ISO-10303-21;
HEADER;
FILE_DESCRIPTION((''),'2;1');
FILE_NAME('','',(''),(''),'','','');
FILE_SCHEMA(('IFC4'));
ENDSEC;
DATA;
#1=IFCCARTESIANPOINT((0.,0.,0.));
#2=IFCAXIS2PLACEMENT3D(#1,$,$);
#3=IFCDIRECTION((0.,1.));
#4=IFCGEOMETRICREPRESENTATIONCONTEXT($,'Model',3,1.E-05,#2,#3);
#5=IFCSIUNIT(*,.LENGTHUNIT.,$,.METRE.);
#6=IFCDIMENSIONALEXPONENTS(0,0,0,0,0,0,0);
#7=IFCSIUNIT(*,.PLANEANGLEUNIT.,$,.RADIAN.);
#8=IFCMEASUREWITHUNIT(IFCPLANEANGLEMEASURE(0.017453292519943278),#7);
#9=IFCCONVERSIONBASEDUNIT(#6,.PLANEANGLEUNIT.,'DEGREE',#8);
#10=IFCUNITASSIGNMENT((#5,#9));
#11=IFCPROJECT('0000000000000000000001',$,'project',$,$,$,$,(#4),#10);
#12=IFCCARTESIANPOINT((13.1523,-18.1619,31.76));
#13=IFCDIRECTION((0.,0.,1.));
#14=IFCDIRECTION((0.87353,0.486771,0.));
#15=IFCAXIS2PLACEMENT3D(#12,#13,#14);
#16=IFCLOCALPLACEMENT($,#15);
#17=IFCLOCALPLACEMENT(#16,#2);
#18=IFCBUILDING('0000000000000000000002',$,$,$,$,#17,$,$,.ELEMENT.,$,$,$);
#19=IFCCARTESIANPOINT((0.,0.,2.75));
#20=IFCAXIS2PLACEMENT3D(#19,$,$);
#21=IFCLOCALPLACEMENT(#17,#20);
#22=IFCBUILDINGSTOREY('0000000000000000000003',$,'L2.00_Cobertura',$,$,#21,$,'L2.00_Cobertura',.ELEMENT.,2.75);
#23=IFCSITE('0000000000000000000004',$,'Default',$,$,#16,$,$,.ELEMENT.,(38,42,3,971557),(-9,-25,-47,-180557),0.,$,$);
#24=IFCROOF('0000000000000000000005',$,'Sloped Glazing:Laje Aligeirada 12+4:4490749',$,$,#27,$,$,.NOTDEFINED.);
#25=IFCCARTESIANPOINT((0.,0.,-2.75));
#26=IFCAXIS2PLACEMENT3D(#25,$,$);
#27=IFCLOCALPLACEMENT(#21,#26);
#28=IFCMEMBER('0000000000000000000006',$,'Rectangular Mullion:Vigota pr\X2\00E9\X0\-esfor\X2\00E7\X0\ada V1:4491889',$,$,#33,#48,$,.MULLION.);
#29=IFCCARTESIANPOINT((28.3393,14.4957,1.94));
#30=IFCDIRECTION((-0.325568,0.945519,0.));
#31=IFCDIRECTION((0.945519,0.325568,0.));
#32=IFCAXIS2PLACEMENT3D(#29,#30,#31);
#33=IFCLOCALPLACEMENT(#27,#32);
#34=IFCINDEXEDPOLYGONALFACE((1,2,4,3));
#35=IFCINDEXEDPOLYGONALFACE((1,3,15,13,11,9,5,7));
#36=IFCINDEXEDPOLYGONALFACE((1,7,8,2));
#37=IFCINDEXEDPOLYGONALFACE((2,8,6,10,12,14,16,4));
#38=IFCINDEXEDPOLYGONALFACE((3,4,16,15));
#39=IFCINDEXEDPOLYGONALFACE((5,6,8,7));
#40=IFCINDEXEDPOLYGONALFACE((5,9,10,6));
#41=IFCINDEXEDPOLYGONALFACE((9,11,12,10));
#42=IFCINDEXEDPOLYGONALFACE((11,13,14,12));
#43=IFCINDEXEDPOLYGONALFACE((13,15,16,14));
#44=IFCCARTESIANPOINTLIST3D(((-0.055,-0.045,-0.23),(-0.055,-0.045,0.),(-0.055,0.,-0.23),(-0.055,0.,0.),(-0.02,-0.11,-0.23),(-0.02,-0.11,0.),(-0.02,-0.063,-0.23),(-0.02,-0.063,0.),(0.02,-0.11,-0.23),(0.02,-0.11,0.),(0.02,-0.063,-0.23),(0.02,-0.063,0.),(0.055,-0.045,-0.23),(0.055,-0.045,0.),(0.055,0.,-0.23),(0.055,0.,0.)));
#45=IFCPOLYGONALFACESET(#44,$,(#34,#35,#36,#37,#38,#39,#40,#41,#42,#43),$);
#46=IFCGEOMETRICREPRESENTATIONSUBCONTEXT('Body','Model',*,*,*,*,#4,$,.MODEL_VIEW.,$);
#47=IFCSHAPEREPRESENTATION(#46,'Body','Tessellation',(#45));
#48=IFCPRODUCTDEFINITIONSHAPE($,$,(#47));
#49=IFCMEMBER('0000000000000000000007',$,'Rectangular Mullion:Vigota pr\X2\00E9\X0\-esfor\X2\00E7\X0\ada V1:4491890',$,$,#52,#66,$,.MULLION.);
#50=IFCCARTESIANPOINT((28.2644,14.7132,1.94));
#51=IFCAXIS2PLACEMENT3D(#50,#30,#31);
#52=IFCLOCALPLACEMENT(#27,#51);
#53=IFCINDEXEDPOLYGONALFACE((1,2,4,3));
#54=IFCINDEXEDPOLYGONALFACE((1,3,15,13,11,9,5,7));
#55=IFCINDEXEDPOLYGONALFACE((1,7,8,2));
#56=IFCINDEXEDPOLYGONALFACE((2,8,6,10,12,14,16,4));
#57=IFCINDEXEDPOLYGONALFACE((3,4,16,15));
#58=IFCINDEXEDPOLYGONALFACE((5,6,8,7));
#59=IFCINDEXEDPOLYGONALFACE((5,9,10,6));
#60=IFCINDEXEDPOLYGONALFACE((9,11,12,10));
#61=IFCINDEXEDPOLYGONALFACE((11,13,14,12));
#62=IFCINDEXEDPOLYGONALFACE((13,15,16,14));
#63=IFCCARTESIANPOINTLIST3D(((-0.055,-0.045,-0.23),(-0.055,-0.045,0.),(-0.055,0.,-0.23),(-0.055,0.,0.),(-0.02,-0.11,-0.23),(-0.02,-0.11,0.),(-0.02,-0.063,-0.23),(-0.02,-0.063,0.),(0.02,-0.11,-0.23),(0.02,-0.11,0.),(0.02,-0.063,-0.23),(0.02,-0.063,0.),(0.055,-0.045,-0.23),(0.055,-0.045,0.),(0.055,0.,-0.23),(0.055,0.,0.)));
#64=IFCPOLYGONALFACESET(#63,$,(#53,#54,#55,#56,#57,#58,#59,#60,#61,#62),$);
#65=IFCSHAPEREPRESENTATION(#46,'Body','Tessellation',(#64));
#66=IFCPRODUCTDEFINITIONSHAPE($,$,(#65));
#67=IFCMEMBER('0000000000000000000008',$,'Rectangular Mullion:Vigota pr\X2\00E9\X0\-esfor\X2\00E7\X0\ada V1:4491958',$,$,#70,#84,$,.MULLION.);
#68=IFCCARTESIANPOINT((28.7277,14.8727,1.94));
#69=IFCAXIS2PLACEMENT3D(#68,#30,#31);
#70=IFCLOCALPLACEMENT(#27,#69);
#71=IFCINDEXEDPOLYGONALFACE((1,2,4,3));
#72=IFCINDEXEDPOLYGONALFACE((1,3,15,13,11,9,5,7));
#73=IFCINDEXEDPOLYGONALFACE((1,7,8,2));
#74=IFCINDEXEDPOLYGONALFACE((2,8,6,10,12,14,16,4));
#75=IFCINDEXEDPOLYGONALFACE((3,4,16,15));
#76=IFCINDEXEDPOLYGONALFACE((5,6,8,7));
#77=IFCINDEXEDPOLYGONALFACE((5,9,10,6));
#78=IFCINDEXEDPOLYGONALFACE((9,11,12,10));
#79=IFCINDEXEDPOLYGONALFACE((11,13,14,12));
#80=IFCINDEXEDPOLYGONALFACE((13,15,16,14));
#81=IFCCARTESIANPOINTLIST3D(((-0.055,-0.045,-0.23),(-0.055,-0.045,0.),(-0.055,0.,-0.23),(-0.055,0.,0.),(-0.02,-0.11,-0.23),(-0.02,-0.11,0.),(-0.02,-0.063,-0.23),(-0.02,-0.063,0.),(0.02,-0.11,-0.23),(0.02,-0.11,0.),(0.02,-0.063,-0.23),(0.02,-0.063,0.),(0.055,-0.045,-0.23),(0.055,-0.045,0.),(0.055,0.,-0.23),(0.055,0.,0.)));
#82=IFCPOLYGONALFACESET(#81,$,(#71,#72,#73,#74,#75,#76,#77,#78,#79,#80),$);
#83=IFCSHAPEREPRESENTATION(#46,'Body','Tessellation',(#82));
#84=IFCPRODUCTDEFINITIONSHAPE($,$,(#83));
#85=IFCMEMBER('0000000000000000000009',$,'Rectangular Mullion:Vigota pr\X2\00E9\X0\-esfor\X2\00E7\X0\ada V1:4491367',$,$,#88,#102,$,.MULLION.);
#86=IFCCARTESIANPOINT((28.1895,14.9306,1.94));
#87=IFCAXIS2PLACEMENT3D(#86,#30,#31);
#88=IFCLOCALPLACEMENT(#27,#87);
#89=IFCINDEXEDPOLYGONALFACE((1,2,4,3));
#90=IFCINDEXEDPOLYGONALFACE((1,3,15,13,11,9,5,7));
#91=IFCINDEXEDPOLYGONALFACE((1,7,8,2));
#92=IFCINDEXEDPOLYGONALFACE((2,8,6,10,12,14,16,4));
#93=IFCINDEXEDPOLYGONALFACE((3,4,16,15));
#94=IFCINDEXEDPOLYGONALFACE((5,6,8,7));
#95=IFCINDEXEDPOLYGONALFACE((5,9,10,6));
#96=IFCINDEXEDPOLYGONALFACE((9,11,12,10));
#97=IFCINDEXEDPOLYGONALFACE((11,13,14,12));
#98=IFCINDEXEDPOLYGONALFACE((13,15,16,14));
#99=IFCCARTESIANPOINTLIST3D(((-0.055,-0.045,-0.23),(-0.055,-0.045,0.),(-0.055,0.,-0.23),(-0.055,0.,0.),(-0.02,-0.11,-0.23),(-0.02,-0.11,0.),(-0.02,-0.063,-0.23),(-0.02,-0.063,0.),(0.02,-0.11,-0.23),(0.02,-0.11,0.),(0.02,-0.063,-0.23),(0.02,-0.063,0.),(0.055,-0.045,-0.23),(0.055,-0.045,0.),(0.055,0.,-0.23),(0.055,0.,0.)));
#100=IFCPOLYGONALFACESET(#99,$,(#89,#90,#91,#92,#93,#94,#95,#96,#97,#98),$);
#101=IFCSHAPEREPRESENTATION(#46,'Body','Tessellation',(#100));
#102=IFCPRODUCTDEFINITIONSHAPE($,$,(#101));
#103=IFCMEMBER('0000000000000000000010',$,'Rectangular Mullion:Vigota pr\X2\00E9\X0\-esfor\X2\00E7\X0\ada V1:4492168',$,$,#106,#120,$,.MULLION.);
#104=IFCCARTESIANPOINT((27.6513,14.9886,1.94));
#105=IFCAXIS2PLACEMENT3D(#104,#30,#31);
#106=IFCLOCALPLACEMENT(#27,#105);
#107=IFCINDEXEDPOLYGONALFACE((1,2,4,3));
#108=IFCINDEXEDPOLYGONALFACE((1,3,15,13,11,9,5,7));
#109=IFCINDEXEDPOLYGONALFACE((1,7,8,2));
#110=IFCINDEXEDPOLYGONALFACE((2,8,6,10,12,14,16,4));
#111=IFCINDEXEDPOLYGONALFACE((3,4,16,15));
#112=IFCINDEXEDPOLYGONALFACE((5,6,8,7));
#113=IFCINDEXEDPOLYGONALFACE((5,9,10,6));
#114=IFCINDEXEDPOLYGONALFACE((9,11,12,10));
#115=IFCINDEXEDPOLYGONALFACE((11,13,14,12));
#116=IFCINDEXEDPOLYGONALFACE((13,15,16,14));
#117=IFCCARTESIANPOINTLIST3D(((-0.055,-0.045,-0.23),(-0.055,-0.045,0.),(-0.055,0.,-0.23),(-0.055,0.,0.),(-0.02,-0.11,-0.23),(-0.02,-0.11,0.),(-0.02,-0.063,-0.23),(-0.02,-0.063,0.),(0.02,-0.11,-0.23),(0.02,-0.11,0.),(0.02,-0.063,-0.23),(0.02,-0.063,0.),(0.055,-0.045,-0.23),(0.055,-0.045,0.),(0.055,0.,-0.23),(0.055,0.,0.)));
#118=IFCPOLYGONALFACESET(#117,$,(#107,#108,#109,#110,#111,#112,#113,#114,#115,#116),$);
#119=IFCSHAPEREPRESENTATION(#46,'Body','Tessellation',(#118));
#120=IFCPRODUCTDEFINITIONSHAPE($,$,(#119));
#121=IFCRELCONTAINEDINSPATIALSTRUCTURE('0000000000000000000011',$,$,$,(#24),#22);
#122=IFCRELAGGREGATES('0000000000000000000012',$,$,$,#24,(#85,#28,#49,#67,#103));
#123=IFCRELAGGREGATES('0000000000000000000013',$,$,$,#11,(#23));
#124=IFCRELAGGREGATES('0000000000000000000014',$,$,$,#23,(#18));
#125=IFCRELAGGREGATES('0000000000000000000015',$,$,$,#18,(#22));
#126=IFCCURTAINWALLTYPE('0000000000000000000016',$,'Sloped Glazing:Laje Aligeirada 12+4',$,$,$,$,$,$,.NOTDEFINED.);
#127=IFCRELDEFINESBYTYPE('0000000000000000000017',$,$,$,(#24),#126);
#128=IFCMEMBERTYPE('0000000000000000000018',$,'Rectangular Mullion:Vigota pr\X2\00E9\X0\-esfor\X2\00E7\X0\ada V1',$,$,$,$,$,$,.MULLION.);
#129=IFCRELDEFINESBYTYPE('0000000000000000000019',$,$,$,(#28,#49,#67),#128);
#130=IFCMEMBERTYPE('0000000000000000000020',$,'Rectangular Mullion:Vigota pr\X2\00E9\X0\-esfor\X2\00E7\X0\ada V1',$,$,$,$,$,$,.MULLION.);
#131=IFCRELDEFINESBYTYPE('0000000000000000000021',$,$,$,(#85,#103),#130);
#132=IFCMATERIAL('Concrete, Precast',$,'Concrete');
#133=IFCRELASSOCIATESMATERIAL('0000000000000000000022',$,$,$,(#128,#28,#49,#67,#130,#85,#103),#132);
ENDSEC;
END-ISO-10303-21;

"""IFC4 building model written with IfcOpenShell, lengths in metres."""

from ifc_helpers import new_model, entity, si_unit, converted_unit, direction, frame, origin, place, context, subcontext, project, spatial, indexed_curve, outline, extrude, source, transform, mapped, material, type_object, type_shapes, element, aggregate, save


model = new_model("IFC4")

# Units and contexts
model_context = context("Model", 3, precision=1e-05, world=origin(), true_north=direction((0.0, 1.0)))
body_context = subcontext(model_context, "Body", "Model", "MODEL_VIEW")
ifc_project = project(units=[si_unit("LENGTHUNIT", "METRE"), converted_unit("PLANEANGLEUNIT", "DEGREE", entity("IfcPlaneAngleMeasure", 0.017453292519943278), si_unit("PLANEANGLEUNIT", "RADIAN"), dimensions=[0, 0, 0, 0, 0, 0, 0])], contexts=[model_context])

# Site, building, storey
site_placement = place(None, frame((13.1523, -18.1619, 31.76), z_axis=(0.0, 0.0, 1.0), x_axis=(0.87353, 0.486771, 0.0)))
site = spatial("IfcSite", under=ifc_project, at=site_placement, Name="Default", CompositionType="ELEMENT", RefLatitude=(38, 42, 3, 971557), RefLongitude=(-9, -25, -47, -180557), RefElevation=0.0)
building_placement = place(site_placement, origin())
building = spatial("IfcBuilding", under=site, at=building_placement, CompositionType="ELEMENT")
storey_placement = place(building_placement, frame((0.0, 0.0, 2.75)))
storey = spatial("IfcBuildingStorey", under=building, at=storey_placement, Name="L2.00_Cobertura", LongName="L2.00_Cobertura", CompositionType="ELEMENT", Elevation=2.75)

# Roof, members
curtain_wall_type = type_object("IfcCurtainWallType", Name="Sloped Glazing:Laje Aligeirada 12+4", PredefinedType="NOTDEFINED")
roof_placement = place(storey_placement, frame((0.0, 0.0, -2.75)))
roof = element("IfcRoof", 1, at=roof_placement, inside=storey, type_object=curtain_wall_type, Name="Sloped Glazing:Laje Aligeirada 12+4:4490749", PredefinedType="NOTDEFINED")
ifc_material_1 = material(Name="Concrete, Precast", Category="Concrete")
member_type_1 = type_object("IfcMemberType", Name="Rectangular Mullion:Vigota pré-esforçada V1", PredefinedType="MULLION", material=ifc_material_1)
shared_shape_1 = source(origin(), body_context, "Body", "SweptSolid", [
    extrude(outline(indexed_curve([(-0.055, -0.0545), (0.055, -0.0545), (0.055, -0.0095), (0.02, 0.0085), (0.02, 0.0555), (-0.02, 0.0555), (-0.02, 0.0085), (-0.055, -0.0095), (-0.055, -0.0545)], self_intersect=False)), frame((0.0, -0.0545, -0.23), z_axis=(0.0, 0.0, 1.0), x_axis=(-1.0, 0.0, 0.0)), (0.0, 0.0, 1.0), 0.23),
])
type_shapes(member_type_1, [shared_shape_1])
member_1_placement = place(roof_placement, frame((28.3393, 14.4957, 1.94), z_axis=(-0.325568, 0.945519, 0.0), x_axis=(0.945519, 0.325568, 0.0)))
member_1 = element("IfcMember", 2, at=member_1_placement, type_object=member_type_1, material=ifc_material_1, Name="Rectangular Mullion:Vigota pré-esforçada V1:4491889", PredefinedType="MULLION", context=body_context, shape_type="MappedRepresentation", body=[
    mapped(shared_shape_1, transform((0.0, 0.0, 0.0), scale=1.0)),
])
member_2_placement = place(roof_placement, frame((28.2644, 14.7132, 1.94), z_axis=(-0.325568, 0.945519, 0.0), x_axis=(0.945519, 0.325568, 0.0)))
member_2 = element("IfcMember", 3, at=member_2_placement, type_object=member_type_1, material=ifc_material_1, Name="Rectangular Mullion:Vigota pré-esforçada V1:4491890", PredefinedType="MULLION", context=body_context, shape_type="MappedRepresentation", body=[
    mapped(shared_shape_1, transform((0.0, 0.0, 0.0), scale=1.0)),
])
member_3_placement = place(roof_placement, frame((28.7277, 14.8727, 1.94), z_axis=(-0.325568, 0.945519, 0.0), x_axis=(0.945519, 0.325568, 0.0)))
member_3 = element("IfcMember", 4, at=member_3_placement, type_object=member_type_1, material=ifc_material_1, Name="Rectangular Mullion:Vigota pré-esforçada V1:4491958", PredefinedType="MULLION", context=body_context, shape_type="MappedRepresentation", body=[
    mapped(shared_shape_1, transform((0.0, 0.0, 0.0), scale=1.0)),
])
member_type_2 = type_object("IfcMemberType", Name="Rectangular Mullion:Vigota pré-esforçada V1", PredefinedType="MULLION", material=ifc_material_1)
shared_shape_2 = source(origin(), body_context, "Body", "SweptSolid", [
    extrude(outline(indexed_curve([(-0.055, -0.0545), (0.055, -0.0545), (0.055, -0.0095), (0.02, 0.0085), (0.02, 0.0555), (-0.02, 0.0555), (-0.02, 0.0085), (-0.055, -0.0095), (-0.055, -0.0545)], self_intersect=False)), frame((0.0, -0.0545, -0.23), z_axis=(0.0, 0.0, 1.0), x_axis=(-1.0, 0.0, 0.0)), (0.0, 0.0, 1.0), 0.23),
])
type_shapes(member_type_2, [shared_shape_2])
member_4_placement = place(roof_placement, frame((28.1895, 14.9306, 1.94), z_axis=(-0.325568, 0.945519, 0.0), x_axis=(0.945519, 0.325568, 0.0)))
member_4 = element("IfcMember", 5, at=member_4_placement, type_object=member_type_2, material=ifc_material_1, Name="Rectangular Mullion:Vigota pré-esforçada V1:4491367", PredefinedType="MULLION", context=body_context, shape_type="MappedRepresentation", body=[
    mapped(shared_shape_2, transform((0.0, 0.0, 0.0), scale=1.0)),
])
member_5_placement = place(roof_placement, frame((27.6513, 14.9886, 1.94), z_axis=(-0.325568, 0.945519, 0.0), x_axis=(0.945519, 0.325568, 0.0)))
member_5 = element("IfcMember", 6, at=member_5_placement, type_object=member_type_2, material=ifc_material_1, Name="Rectangular Mullion:Vigota pré-esforçada V1:4492168", PredefinedType="MULLION", context=body_context, shape_type="MappedRepresentation", body=[
    mapped(shared_shape_2, transform((0.0, 0.0, 0.0), scale=1.0)),
])
aggregate(roof, [member_4, member_1, member_2, member_3, member_5])

save(model, "model.ifc")
